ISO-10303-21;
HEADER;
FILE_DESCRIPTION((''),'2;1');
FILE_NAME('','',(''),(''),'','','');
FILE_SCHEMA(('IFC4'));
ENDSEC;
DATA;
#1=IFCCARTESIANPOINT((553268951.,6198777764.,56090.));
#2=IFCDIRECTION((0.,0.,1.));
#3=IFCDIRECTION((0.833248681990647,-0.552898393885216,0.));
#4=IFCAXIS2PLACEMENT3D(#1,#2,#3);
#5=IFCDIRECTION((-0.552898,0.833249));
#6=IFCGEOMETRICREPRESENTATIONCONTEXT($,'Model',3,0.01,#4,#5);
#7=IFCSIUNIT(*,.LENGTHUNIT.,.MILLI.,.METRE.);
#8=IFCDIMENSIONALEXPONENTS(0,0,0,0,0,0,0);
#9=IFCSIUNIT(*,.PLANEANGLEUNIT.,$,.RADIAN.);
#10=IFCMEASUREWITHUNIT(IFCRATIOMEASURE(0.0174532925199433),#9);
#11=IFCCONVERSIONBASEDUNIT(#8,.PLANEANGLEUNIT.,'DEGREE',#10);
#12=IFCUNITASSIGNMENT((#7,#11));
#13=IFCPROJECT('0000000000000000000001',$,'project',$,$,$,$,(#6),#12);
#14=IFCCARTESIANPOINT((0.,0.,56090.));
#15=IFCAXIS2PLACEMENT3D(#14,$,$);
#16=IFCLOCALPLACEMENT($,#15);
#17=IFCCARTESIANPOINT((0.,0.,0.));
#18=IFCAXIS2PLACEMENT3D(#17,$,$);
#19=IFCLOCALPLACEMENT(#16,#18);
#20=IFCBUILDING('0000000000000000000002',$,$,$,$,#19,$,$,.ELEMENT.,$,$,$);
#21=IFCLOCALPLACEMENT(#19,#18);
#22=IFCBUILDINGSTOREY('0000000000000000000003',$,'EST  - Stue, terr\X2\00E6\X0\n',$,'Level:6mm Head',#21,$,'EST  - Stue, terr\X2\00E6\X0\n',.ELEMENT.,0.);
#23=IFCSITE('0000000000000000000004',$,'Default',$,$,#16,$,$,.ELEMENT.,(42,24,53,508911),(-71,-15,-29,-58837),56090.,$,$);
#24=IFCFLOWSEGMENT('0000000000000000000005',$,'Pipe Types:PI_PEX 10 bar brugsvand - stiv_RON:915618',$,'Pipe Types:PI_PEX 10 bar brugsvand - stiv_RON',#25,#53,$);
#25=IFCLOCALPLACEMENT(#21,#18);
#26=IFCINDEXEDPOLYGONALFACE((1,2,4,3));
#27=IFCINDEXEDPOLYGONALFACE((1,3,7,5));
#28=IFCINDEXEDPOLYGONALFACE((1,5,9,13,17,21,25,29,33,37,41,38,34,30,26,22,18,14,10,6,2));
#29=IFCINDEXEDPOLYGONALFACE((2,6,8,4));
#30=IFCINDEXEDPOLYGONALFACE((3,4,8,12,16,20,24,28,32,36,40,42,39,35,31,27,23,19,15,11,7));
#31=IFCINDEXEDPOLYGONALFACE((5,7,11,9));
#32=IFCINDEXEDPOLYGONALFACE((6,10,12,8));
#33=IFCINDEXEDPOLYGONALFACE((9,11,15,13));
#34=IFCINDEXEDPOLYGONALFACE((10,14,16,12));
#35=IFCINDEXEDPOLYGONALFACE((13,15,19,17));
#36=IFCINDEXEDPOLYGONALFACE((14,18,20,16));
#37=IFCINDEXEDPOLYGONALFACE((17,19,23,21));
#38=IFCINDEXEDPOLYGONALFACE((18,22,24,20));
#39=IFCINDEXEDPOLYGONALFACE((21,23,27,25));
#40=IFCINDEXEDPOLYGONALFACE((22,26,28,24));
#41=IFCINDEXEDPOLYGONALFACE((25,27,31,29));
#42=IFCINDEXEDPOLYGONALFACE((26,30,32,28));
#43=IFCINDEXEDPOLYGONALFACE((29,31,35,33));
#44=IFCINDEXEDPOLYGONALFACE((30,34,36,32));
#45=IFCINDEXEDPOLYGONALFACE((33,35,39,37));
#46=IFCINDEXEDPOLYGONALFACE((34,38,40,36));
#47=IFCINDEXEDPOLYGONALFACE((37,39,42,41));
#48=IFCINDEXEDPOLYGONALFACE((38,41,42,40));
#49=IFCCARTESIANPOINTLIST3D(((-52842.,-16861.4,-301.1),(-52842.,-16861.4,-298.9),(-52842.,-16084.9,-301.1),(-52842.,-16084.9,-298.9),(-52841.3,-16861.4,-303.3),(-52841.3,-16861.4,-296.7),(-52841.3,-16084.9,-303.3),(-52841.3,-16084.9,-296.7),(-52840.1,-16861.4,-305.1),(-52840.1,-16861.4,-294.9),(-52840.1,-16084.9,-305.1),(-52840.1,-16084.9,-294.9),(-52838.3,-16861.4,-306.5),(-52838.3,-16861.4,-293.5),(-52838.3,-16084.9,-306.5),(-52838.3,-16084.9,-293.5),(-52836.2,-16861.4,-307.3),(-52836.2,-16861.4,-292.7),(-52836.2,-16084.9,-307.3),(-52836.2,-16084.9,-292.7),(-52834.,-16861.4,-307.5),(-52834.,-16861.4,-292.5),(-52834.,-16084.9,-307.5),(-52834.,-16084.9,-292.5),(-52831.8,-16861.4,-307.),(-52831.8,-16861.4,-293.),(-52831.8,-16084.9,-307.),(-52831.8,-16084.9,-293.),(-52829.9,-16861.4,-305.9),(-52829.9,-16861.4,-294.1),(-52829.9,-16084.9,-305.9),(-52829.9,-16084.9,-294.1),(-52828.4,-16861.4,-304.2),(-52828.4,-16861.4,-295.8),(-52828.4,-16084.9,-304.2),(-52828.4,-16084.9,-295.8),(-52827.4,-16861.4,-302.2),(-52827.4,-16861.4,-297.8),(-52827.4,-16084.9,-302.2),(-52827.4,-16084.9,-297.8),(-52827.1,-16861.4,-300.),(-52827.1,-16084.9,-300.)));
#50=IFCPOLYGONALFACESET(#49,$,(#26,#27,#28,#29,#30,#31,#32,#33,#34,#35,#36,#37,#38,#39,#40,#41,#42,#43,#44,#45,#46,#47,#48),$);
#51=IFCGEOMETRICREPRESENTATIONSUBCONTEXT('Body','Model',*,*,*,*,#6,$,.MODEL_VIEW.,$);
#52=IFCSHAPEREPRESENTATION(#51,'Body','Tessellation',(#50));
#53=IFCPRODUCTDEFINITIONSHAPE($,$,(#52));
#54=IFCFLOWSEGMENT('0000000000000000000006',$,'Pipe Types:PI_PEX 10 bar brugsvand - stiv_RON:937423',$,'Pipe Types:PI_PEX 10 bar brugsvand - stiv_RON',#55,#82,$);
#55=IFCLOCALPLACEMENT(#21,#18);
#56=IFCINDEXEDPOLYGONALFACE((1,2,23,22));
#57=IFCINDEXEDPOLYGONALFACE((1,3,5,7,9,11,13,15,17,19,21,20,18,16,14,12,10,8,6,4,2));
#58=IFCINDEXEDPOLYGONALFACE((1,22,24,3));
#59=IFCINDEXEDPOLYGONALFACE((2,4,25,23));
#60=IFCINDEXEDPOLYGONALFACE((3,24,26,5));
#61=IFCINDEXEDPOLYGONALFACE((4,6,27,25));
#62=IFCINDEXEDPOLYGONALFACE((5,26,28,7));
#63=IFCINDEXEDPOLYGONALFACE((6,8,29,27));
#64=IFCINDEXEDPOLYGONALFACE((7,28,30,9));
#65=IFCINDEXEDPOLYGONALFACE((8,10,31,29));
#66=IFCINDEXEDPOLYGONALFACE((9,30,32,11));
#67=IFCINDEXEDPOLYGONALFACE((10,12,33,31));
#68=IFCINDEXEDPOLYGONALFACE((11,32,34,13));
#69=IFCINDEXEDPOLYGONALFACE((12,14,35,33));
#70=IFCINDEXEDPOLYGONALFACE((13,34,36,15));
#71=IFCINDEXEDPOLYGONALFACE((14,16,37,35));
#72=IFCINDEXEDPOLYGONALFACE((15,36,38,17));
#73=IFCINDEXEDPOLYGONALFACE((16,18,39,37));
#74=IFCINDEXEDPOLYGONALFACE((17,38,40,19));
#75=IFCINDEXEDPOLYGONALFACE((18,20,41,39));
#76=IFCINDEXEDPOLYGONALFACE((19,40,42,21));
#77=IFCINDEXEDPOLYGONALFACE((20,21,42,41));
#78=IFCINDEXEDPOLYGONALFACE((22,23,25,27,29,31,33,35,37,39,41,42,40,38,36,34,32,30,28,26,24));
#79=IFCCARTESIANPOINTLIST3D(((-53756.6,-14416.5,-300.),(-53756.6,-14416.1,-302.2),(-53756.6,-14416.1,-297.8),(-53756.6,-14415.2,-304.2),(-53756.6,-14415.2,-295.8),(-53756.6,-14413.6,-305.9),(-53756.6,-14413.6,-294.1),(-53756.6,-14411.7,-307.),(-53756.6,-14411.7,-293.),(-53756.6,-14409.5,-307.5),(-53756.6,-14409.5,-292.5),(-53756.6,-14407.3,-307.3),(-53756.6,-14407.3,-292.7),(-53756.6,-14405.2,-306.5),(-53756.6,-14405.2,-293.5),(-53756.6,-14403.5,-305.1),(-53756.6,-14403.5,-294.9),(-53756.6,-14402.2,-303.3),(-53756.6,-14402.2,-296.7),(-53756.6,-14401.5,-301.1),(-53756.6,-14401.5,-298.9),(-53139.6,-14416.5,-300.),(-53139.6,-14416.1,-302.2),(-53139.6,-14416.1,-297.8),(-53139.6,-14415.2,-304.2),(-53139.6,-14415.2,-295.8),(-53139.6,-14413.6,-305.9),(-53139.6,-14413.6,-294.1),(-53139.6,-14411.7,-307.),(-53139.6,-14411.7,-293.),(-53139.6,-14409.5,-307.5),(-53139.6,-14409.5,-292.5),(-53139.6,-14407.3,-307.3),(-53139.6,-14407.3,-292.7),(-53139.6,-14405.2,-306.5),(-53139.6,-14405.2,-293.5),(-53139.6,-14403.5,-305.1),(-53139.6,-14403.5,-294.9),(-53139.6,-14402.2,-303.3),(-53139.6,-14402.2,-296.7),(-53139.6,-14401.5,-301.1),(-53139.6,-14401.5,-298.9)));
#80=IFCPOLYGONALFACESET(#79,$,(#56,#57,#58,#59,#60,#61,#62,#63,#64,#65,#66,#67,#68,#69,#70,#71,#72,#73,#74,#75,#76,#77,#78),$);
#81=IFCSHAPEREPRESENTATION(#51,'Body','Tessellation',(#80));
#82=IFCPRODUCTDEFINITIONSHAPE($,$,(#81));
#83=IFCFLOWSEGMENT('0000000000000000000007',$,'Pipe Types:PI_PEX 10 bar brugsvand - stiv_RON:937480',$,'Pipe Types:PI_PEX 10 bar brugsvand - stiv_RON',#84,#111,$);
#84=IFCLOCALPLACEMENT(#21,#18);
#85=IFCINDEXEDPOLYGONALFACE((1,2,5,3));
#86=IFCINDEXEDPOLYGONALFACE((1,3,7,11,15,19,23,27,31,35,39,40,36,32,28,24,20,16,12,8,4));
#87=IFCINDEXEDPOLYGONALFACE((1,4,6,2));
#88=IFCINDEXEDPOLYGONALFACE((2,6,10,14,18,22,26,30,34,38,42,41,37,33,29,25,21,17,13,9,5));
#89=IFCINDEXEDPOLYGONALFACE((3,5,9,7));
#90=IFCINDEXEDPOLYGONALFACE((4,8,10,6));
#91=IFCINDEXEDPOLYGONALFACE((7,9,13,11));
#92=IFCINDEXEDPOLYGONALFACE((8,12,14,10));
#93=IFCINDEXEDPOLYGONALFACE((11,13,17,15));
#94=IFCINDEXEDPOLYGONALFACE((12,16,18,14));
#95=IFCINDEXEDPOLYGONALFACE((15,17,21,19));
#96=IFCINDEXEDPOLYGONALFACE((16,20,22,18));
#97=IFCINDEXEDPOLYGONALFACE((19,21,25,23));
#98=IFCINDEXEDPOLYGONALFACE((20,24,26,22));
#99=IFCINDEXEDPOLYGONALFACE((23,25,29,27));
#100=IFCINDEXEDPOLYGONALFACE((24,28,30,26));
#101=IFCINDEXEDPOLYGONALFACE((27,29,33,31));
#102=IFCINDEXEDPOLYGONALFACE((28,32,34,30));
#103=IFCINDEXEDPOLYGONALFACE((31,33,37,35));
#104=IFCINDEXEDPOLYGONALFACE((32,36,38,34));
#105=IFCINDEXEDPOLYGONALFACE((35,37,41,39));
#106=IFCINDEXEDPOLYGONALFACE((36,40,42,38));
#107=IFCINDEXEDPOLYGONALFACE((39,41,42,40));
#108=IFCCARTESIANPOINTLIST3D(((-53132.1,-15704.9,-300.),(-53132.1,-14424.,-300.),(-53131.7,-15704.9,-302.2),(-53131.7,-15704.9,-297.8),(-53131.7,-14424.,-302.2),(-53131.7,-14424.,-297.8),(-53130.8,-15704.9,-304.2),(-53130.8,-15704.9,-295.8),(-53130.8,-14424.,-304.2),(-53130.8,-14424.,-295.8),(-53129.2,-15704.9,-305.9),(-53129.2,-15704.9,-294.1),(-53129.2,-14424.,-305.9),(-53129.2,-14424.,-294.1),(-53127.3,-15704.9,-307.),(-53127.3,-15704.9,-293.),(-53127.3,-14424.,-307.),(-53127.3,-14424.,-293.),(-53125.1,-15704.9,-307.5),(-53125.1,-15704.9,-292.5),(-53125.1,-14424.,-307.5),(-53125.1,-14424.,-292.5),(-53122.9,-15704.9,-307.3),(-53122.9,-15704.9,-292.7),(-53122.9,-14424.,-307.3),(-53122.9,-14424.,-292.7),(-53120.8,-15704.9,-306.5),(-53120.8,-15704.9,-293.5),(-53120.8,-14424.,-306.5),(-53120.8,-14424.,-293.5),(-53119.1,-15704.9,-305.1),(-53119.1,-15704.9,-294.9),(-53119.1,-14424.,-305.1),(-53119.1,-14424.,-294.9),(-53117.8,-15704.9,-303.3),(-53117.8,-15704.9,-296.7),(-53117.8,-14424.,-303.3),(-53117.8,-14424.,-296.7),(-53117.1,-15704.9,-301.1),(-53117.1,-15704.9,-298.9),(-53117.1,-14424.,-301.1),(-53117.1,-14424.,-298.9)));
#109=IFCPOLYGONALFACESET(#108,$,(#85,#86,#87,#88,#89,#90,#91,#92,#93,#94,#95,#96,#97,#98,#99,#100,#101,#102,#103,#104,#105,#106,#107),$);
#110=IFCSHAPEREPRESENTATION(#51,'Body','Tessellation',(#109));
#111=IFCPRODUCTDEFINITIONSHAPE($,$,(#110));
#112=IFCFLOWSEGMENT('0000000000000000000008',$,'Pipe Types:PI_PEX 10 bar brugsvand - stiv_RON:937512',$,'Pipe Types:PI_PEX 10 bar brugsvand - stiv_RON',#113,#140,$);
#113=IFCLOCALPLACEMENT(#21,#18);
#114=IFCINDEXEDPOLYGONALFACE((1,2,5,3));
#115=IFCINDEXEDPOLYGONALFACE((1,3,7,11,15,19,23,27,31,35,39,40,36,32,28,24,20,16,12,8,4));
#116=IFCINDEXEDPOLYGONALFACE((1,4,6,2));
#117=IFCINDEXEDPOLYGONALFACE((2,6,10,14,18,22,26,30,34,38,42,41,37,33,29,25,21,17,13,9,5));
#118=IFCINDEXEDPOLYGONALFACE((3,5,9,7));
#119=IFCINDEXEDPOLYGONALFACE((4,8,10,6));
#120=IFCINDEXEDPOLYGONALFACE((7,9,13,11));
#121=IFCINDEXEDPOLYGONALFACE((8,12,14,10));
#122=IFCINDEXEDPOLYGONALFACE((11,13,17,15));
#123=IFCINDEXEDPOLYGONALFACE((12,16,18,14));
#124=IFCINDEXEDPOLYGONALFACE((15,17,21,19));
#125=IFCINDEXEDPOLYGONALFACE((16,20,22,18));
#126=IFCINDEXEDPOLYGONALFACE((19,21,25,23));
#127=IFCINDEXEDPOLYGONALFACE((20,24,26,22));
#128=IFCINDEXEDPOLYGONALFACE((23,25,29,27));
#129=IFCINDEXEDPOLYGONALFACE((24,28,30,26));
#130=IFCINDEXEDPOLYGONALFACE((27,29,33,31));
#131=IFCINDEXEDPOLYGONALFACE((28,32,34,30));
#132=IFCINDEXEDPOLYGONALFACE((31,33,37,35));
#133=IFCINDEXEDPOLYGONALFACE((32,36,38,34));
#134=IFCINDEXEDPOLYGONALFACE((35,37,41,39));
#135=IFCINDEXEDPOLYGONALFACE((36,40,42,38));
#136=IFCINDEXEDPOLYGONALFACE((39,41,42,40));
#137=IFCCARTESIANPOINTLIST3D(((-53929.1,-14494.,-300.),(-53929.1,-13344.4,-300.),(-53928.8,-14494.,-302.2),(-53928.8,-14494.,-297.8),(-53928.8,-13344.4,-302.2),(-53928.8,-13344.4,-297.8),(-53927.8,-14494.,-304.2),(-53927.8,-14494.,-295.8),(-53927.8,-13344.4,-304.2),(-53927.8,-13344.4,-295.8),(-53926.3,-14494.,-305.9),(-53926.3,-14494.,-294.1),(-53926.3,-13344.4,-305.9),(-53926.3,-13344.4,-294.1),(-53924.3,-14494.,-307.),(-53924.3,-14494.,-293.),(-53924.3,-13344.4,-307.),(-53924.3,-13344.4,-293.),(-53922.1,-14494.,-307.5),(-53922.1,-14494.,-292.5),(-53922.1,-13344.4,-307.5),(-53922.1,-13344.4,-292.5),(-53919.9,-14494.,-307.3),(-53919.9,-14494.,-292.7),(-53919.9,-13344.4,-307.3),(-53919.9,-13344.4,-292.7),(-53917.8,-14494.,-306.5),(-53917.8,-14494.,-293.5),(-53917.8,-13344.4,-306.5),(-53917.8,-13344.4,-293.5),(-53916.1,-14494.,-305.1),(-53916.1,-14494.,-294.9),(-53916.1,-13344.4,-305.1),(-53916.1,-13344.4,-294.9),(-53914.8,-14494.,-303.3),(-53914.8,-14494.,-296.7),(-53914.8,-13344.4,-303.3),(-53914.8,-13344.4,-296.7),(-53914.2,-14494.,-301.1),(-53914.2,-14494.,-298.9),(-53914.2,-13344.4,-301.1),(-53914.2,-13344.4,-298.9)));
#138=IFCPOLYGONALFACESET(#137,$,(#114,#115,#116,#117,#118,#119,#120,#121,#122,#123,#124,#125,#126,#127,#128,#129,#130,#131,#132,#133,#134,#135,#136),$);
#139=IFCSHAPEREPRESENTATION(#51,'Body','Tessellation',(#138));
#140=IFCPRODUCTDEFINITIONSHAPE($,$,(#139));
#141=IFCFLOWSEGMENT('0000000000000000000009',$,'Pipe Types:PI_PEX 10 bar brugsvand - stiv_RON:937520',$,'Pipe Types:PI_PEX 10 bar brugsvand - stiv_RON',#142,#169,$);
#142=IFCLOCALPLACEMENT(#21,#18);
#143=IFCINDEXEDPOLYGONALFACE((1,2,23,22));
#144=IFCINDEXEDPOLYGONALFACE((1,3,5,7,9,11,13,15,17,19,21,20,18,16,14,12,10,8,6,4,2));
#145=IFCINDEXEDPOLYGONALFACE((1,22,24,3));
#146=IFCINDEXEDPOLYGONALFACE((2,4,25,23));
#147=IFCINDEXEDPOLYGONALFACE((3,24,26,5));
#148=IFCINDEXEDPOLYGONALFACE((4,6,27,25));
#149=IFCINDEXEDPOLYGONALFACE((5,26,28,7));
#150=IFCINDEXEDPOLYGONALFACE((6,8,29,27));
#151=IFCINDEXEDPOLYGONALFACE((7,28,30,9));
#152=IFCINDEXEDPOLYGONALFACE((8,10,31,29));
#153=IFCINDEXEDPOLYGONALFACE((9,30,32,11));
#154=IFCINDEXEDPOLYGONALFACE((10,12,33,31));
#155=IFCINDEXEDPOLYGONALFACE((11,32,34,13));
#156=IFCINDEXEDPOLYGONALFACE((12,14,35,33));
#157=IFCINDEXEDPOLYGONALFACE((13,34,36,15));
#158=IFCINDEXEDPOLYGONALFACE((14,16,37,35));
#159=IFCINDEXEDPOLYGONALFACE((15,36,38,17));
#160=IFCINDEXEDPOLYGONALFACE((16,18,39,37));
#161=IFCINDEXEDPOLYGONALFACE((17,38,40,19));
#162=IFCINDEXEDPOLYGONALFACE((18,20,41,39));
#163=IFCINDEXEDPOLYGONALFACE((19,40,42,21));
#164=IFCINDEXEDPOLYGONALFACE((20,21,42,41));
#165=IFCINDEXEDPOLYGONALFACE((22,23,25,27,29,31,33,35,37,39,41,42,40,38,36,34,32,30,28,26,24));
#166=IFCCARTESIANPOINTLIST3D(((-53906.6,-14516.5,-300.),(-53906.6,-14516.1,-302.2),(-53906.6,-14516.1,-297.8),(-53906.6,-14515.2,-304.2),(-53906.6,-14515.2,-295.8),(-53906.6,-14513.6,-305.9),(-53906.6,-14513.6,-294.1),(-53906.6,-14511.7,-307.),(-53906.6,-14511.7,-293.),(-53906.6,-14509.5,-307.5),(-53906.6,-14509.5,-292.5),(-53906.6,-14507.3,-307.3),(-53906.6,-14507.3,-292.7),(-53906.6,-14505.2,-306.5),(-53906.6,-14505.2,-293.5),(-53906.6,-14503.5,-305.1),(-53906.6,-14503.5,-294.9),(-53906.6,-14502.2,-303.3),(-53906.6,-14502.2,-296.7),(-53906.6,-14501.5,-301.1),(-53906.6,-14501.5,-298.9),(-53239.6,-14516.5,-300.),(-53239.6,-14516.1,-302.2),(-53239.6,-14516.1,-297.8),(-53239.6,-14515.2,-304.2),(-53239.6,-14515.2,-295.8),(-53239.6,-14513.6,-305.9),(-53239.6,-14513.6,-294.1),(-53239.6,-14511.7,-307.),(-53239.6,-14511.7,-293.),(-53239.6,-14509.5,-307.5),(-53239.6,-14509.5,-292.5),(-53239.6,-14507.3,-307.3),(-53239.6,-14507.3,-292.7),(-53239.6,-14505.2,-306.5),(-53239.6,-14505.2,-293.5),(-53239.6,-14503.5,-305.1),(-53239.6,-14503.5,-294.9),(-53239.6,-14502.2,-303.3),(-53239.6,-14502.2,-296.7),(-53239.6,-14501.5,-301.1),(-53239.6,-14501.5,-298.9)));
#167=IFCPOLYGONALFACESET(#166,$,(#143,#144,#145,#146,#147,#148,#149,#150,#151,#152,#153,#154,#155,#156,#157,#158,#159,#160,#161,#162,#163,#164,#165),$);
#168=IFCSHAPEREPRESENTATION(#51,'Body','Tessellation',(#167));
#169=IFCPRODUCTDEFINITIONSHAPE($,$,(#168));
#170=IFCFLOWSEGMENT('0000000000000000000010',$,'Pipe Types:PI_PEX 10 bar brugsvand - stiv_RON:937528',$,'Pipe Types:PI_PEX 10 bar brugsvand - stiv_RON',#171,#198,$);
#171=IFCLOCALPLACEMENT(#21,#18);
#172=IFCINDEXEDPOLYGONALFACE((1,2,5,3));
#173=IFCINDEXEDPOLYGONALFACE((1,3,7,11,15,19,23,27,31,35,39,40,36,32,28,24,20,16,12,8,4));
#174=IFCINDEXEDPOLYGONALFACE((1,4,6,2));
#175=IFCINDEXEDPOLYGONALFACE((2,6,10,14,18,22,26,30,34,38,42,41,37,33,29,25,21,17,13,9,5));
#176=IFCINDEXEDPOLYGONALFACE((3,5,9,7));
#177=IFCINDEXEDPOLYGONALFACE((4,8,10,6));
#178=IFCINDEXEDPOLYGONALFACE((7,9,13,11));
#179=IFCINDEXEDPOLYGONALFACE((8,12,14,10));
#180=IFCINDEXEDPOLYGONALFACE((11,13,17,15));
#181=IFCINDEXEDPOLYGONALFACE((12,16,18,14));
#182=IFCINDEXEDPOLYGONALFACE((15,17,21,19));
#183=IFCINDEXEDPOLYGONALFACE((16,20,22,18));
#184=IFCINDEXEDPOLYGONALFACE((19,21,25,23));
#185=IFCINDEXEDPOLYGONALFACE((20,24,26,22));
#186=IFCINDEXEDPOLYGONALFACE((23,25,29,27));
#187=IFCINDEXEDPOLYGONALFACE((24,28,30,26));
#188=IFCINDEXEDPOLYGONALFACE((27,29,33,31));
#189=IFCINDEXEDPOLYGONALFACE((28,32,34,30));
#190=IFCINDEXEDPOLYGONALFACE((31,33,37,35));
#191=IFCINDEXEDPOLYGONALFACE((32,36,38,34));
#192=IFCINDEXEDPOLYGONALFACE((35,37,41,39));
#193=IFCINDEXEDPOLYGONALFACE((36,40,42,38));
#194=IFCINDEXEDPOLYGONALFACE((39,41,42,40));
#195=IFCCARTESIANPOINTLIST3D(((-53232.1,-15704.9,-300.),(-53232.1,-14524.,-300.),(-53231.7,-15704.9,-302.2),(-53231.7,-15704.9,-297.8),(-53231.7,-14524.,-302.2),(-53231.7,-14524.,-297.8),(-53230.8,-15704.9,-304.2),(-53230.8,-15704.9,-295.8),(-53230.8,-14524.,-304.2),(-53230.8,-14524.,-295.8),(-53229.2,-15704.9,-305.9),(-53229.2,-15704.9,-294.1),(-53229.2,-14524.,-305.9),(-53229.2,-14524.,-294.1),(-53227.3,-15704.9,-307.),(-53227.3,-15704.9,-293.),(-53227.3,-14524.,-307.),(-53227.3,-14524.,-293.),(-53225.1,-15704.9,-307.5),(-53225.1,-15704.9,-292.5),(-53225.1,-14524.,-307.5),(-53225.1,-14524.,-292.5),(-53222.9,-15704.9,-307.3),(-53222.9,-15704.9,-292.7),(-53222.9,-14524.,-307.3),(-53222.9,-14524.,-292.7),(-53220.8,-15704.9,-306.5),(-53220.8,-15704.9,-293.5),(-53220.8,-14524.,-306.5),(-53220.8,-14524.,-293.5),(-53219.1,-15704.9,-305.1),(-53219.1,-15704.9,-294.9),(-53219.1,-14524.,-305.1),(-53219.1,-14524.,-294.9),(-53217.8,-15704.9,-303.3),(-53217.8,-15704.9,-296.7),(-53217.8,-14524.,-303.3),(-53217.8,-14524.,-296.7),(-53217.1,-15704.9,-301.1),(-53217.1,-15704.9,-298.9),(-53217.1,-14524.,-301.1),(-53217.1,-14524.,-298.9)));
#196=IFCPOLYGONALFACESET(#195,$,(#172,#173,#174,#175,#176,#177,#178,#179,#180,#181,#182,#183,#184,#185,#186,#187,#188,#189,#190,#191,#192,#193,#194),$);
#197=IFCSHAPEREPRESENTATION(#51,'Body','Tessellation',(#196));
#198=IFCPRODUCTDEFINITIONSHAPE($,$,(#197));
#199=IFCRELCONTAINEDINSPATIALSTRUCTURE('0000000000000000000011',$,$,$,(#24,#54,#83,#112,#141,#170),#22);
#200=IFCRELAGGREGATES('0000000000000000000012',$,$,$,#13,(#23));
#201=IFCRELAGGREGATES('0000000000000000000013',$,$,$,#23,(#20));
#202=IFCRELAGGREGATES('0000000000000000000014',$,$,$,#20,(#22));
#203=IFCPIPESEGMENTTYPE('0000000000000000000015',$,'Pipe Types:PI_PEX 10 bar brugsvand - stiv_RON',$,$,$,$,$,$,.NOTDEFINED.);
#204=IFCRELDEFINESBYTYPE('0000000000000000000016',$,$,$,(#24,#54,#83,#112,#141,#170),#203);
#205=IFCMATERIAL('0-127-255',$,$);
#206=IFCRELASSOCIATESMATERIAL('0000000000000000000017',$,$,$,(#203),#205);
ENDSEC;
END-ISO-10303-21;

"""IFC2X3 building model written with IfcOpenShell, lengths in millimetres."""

from ifc_helpers import new_model, entity, si_unit, converted_unit, direction, frame, origin, origin_2d_with_axis, place, context, subcontext, project, spatial, circle, extrude, material, type_object, element, save


model = new_model("IFC2X3")

# Units and contexts
model_context = context("Model", 3, precision=0.01, world=frame((553268951.0, 6198777764.0, 56090.0), z_axis=(0.0, 0.0, 1.0), x_axis=(0.833248681990647, -0.552898393885216, 0.0)), true_north=direction((-0.552898, 0.833249)))
body_context = subcontext(model_context, "Body", "Model", "MODEL_VIEW")
ifc_project = project(units=[si_unit("LENGTHUNIT", "METRE", prefix="MILLI"), converted_unit("PLANEANGLEUNIT", "DEGREE", entity("IfcRatioMeasure", 0.0174532925199433), si_unit("PLANEANGLEUNIT", "RADIAN"), dimensions=[0, 0, 0, 0, 0, 0, 0])], contexts=[model_context])

# Site, building, storey
site_placement = place(None, frame((0.0, 0.0, 56090.0)))
site = spatial("IfcSite", under=ifc_project, at=site_placement, Name="Default", CompositionType="ELEMENT", RefLatitude=(42, 24, 53, 508911), RefLongitude=(-71, -15, -29, -58837), RefElevation=56090.0)
building_placement = place(site_placement, origin())
building = spatial("IfcBuilding", under=site, at=building_placement, CompositionType="ELEMENT")
storey_placement = place(building_placement, frame((0.0, 0.0, 0.0)))
storey = spatial("IfcBuildingStorey", under=building, at=storey_placement, Name="EST  - Stue, terræn", ObjectType="Level:6mm Head", LongName="EST  - Stue, terræn", CompositionType="ELEMENT", Elevation=0.0)

# Flow segments
ifc_material_1 = material(Name="0-127-255")
pipe_segment_type_1 = type_object("IfcPipeSegmentType", Name="Pipe Types:PI_PEX 10 bar brugsvand - stiv_RON", PredefinedType="NOTDEFINED", material=ifc_material_1)
flow_segment_1_placement = place(storey_placement, origin())
element("IfcFlowSegment", 1, at=flow_segment_1_placement, inside=storey, type_object=pipe_segment_type_1, Name="Pipe Types:PI_PEX 10 bar brugsvand - stiv_RON:915618", ObjectType="Pipe Types:PI_PEX 10 bar brugsvand - stiv_RON", context=body_context, shape_type="SweptSolid", body=[
    extrude(circle(Radius=7.5, at=origin_2d_with_axis()), frame((-52834.6, -16861.4, -300.0), z_axis=(0.0, 1.0, 0.0), x_axis=(1.0, 0.0, 0.0)), (0.0, 0.0, 1.0), 776.5),
])
flow_segment_2_placement = place(storey_placement, origin())
element("IfcFlowSegment", 2, at=flow_segment_2_placement, inside=storey, type_object=pipe_segment_type_1, Name="Pipe Types:PI_PEX 10 bar brugsvand - stiv_RON:937423", ObjectType="Pipe Types:PI_PEX 10 bar brugsvand - stiv_RON", context=body_context, shape_type="SweptSolid", body=[
    extrude(circle(Radius=7.5, at=origin_2d_with_axis()), frame((-53756.6, -14409.0, -300.0), z_axis=(1.0, 0.0, 0.0), x_axis=(0.0, -1.0, 0.0)), (0.0, 0.0, 1.0), 617.0),
])
flow_segment_3_placement = place(storey_placement, origin())
element("IfcFlowSegment", 3, at=flow_segment_3_placement, inside=storey, type_object=pipe_segment_type_1, Name="Pipe Types:PI_PEX 10 bar brugsvand - stiv_RON:937480", ObjectType="Pipe Types:PI_PEX 10 bar brugsvand - stiv_RON", context=body_context, shape_type="SweptSolid", body=[
    extrude(circle(Radius=7.5, at=origin_2d_with_axis()), frame((-53124.6, -15704.9, -300.0), z_axis=(0.0, 1.0, 0.0), x_axis=(-1.0, 0.0, 0.0)), (0.0, 0.0, 1.0), 1280.9),
])
flow_segment_4_placement = place(storey_placement, origin())
element("IfcFlowSegment", 4, at=flow_segment_4_placement, inside=storey, type_object=pipe_segment_type_1, Name="Pipe Types:PI_PEX 10 bar brugsvand - stiv_RON:937512", ObjectType="Pipe Types:PI_PEX 10 bar brugsvand - stiv_RON", context=body_context, shape_type="SweptSolid", body=[
    extrude(circle(Radius=7.5, at=origin_2d_with_axis()), frame((-53921.6, -14494.0, -300.0), z_axis=(0.0, 1.0, 0.0), x_axis=(-1.0, 0.0, 0.0)), (0.0, 0.0, 1.0), 1149.6),
])
flow_segment_5_placement = place(storey_placement, origin())
element("IfcFlowSegment", 5, at=flow_segment_5_placement, inside=storey, type_object=pipe_segment_type_1, Name="Pipe Types:PI_PEX 10 bar brugsvand - stiv_RON:937520", ObjectType="Pipe Types:PI_PEX 10 bar brugsvand - stiv_RON", context=body_context, shape_type="SweptSolid", body=[
    extrude(circle(Radius=7.5, at=origin_2d_with_axis()), frame((-53906.6, -14509.0, -300.0), z_axis=(1.0, 0.0, 0.0), x_axis=(0.0, -1.0, 0.0)), (0.0, 0.0, 1.0), 667.0),
])
flow_segment_6_placement = place(storey_placement, origin())
element("IfcFlowSegment", 6, at=flow_segment_6_placement, inside=storey, type_object=pipe_segment_type_1, Name="Pipe Types:PI_PEX 10 bar brugsvand - stiv_RON:937528", ObjectType="Pipe Types:PI_PEX 10 bar brugsvand - stiv_RON", context=body_context, shape_type="SweptSolid", body=[
    extrude(circle(Radius=7.5, at=origin_2d_with_axis()), frame((-53224.6, -15704.9, -300.0), z_axis=(0.0, 1.0, 0.0), x_axis=(-1.0, 0.0, 0.0)), (0.0, 0.0, 1.0), 1180.9),
])

save(model, "model.ifc")
